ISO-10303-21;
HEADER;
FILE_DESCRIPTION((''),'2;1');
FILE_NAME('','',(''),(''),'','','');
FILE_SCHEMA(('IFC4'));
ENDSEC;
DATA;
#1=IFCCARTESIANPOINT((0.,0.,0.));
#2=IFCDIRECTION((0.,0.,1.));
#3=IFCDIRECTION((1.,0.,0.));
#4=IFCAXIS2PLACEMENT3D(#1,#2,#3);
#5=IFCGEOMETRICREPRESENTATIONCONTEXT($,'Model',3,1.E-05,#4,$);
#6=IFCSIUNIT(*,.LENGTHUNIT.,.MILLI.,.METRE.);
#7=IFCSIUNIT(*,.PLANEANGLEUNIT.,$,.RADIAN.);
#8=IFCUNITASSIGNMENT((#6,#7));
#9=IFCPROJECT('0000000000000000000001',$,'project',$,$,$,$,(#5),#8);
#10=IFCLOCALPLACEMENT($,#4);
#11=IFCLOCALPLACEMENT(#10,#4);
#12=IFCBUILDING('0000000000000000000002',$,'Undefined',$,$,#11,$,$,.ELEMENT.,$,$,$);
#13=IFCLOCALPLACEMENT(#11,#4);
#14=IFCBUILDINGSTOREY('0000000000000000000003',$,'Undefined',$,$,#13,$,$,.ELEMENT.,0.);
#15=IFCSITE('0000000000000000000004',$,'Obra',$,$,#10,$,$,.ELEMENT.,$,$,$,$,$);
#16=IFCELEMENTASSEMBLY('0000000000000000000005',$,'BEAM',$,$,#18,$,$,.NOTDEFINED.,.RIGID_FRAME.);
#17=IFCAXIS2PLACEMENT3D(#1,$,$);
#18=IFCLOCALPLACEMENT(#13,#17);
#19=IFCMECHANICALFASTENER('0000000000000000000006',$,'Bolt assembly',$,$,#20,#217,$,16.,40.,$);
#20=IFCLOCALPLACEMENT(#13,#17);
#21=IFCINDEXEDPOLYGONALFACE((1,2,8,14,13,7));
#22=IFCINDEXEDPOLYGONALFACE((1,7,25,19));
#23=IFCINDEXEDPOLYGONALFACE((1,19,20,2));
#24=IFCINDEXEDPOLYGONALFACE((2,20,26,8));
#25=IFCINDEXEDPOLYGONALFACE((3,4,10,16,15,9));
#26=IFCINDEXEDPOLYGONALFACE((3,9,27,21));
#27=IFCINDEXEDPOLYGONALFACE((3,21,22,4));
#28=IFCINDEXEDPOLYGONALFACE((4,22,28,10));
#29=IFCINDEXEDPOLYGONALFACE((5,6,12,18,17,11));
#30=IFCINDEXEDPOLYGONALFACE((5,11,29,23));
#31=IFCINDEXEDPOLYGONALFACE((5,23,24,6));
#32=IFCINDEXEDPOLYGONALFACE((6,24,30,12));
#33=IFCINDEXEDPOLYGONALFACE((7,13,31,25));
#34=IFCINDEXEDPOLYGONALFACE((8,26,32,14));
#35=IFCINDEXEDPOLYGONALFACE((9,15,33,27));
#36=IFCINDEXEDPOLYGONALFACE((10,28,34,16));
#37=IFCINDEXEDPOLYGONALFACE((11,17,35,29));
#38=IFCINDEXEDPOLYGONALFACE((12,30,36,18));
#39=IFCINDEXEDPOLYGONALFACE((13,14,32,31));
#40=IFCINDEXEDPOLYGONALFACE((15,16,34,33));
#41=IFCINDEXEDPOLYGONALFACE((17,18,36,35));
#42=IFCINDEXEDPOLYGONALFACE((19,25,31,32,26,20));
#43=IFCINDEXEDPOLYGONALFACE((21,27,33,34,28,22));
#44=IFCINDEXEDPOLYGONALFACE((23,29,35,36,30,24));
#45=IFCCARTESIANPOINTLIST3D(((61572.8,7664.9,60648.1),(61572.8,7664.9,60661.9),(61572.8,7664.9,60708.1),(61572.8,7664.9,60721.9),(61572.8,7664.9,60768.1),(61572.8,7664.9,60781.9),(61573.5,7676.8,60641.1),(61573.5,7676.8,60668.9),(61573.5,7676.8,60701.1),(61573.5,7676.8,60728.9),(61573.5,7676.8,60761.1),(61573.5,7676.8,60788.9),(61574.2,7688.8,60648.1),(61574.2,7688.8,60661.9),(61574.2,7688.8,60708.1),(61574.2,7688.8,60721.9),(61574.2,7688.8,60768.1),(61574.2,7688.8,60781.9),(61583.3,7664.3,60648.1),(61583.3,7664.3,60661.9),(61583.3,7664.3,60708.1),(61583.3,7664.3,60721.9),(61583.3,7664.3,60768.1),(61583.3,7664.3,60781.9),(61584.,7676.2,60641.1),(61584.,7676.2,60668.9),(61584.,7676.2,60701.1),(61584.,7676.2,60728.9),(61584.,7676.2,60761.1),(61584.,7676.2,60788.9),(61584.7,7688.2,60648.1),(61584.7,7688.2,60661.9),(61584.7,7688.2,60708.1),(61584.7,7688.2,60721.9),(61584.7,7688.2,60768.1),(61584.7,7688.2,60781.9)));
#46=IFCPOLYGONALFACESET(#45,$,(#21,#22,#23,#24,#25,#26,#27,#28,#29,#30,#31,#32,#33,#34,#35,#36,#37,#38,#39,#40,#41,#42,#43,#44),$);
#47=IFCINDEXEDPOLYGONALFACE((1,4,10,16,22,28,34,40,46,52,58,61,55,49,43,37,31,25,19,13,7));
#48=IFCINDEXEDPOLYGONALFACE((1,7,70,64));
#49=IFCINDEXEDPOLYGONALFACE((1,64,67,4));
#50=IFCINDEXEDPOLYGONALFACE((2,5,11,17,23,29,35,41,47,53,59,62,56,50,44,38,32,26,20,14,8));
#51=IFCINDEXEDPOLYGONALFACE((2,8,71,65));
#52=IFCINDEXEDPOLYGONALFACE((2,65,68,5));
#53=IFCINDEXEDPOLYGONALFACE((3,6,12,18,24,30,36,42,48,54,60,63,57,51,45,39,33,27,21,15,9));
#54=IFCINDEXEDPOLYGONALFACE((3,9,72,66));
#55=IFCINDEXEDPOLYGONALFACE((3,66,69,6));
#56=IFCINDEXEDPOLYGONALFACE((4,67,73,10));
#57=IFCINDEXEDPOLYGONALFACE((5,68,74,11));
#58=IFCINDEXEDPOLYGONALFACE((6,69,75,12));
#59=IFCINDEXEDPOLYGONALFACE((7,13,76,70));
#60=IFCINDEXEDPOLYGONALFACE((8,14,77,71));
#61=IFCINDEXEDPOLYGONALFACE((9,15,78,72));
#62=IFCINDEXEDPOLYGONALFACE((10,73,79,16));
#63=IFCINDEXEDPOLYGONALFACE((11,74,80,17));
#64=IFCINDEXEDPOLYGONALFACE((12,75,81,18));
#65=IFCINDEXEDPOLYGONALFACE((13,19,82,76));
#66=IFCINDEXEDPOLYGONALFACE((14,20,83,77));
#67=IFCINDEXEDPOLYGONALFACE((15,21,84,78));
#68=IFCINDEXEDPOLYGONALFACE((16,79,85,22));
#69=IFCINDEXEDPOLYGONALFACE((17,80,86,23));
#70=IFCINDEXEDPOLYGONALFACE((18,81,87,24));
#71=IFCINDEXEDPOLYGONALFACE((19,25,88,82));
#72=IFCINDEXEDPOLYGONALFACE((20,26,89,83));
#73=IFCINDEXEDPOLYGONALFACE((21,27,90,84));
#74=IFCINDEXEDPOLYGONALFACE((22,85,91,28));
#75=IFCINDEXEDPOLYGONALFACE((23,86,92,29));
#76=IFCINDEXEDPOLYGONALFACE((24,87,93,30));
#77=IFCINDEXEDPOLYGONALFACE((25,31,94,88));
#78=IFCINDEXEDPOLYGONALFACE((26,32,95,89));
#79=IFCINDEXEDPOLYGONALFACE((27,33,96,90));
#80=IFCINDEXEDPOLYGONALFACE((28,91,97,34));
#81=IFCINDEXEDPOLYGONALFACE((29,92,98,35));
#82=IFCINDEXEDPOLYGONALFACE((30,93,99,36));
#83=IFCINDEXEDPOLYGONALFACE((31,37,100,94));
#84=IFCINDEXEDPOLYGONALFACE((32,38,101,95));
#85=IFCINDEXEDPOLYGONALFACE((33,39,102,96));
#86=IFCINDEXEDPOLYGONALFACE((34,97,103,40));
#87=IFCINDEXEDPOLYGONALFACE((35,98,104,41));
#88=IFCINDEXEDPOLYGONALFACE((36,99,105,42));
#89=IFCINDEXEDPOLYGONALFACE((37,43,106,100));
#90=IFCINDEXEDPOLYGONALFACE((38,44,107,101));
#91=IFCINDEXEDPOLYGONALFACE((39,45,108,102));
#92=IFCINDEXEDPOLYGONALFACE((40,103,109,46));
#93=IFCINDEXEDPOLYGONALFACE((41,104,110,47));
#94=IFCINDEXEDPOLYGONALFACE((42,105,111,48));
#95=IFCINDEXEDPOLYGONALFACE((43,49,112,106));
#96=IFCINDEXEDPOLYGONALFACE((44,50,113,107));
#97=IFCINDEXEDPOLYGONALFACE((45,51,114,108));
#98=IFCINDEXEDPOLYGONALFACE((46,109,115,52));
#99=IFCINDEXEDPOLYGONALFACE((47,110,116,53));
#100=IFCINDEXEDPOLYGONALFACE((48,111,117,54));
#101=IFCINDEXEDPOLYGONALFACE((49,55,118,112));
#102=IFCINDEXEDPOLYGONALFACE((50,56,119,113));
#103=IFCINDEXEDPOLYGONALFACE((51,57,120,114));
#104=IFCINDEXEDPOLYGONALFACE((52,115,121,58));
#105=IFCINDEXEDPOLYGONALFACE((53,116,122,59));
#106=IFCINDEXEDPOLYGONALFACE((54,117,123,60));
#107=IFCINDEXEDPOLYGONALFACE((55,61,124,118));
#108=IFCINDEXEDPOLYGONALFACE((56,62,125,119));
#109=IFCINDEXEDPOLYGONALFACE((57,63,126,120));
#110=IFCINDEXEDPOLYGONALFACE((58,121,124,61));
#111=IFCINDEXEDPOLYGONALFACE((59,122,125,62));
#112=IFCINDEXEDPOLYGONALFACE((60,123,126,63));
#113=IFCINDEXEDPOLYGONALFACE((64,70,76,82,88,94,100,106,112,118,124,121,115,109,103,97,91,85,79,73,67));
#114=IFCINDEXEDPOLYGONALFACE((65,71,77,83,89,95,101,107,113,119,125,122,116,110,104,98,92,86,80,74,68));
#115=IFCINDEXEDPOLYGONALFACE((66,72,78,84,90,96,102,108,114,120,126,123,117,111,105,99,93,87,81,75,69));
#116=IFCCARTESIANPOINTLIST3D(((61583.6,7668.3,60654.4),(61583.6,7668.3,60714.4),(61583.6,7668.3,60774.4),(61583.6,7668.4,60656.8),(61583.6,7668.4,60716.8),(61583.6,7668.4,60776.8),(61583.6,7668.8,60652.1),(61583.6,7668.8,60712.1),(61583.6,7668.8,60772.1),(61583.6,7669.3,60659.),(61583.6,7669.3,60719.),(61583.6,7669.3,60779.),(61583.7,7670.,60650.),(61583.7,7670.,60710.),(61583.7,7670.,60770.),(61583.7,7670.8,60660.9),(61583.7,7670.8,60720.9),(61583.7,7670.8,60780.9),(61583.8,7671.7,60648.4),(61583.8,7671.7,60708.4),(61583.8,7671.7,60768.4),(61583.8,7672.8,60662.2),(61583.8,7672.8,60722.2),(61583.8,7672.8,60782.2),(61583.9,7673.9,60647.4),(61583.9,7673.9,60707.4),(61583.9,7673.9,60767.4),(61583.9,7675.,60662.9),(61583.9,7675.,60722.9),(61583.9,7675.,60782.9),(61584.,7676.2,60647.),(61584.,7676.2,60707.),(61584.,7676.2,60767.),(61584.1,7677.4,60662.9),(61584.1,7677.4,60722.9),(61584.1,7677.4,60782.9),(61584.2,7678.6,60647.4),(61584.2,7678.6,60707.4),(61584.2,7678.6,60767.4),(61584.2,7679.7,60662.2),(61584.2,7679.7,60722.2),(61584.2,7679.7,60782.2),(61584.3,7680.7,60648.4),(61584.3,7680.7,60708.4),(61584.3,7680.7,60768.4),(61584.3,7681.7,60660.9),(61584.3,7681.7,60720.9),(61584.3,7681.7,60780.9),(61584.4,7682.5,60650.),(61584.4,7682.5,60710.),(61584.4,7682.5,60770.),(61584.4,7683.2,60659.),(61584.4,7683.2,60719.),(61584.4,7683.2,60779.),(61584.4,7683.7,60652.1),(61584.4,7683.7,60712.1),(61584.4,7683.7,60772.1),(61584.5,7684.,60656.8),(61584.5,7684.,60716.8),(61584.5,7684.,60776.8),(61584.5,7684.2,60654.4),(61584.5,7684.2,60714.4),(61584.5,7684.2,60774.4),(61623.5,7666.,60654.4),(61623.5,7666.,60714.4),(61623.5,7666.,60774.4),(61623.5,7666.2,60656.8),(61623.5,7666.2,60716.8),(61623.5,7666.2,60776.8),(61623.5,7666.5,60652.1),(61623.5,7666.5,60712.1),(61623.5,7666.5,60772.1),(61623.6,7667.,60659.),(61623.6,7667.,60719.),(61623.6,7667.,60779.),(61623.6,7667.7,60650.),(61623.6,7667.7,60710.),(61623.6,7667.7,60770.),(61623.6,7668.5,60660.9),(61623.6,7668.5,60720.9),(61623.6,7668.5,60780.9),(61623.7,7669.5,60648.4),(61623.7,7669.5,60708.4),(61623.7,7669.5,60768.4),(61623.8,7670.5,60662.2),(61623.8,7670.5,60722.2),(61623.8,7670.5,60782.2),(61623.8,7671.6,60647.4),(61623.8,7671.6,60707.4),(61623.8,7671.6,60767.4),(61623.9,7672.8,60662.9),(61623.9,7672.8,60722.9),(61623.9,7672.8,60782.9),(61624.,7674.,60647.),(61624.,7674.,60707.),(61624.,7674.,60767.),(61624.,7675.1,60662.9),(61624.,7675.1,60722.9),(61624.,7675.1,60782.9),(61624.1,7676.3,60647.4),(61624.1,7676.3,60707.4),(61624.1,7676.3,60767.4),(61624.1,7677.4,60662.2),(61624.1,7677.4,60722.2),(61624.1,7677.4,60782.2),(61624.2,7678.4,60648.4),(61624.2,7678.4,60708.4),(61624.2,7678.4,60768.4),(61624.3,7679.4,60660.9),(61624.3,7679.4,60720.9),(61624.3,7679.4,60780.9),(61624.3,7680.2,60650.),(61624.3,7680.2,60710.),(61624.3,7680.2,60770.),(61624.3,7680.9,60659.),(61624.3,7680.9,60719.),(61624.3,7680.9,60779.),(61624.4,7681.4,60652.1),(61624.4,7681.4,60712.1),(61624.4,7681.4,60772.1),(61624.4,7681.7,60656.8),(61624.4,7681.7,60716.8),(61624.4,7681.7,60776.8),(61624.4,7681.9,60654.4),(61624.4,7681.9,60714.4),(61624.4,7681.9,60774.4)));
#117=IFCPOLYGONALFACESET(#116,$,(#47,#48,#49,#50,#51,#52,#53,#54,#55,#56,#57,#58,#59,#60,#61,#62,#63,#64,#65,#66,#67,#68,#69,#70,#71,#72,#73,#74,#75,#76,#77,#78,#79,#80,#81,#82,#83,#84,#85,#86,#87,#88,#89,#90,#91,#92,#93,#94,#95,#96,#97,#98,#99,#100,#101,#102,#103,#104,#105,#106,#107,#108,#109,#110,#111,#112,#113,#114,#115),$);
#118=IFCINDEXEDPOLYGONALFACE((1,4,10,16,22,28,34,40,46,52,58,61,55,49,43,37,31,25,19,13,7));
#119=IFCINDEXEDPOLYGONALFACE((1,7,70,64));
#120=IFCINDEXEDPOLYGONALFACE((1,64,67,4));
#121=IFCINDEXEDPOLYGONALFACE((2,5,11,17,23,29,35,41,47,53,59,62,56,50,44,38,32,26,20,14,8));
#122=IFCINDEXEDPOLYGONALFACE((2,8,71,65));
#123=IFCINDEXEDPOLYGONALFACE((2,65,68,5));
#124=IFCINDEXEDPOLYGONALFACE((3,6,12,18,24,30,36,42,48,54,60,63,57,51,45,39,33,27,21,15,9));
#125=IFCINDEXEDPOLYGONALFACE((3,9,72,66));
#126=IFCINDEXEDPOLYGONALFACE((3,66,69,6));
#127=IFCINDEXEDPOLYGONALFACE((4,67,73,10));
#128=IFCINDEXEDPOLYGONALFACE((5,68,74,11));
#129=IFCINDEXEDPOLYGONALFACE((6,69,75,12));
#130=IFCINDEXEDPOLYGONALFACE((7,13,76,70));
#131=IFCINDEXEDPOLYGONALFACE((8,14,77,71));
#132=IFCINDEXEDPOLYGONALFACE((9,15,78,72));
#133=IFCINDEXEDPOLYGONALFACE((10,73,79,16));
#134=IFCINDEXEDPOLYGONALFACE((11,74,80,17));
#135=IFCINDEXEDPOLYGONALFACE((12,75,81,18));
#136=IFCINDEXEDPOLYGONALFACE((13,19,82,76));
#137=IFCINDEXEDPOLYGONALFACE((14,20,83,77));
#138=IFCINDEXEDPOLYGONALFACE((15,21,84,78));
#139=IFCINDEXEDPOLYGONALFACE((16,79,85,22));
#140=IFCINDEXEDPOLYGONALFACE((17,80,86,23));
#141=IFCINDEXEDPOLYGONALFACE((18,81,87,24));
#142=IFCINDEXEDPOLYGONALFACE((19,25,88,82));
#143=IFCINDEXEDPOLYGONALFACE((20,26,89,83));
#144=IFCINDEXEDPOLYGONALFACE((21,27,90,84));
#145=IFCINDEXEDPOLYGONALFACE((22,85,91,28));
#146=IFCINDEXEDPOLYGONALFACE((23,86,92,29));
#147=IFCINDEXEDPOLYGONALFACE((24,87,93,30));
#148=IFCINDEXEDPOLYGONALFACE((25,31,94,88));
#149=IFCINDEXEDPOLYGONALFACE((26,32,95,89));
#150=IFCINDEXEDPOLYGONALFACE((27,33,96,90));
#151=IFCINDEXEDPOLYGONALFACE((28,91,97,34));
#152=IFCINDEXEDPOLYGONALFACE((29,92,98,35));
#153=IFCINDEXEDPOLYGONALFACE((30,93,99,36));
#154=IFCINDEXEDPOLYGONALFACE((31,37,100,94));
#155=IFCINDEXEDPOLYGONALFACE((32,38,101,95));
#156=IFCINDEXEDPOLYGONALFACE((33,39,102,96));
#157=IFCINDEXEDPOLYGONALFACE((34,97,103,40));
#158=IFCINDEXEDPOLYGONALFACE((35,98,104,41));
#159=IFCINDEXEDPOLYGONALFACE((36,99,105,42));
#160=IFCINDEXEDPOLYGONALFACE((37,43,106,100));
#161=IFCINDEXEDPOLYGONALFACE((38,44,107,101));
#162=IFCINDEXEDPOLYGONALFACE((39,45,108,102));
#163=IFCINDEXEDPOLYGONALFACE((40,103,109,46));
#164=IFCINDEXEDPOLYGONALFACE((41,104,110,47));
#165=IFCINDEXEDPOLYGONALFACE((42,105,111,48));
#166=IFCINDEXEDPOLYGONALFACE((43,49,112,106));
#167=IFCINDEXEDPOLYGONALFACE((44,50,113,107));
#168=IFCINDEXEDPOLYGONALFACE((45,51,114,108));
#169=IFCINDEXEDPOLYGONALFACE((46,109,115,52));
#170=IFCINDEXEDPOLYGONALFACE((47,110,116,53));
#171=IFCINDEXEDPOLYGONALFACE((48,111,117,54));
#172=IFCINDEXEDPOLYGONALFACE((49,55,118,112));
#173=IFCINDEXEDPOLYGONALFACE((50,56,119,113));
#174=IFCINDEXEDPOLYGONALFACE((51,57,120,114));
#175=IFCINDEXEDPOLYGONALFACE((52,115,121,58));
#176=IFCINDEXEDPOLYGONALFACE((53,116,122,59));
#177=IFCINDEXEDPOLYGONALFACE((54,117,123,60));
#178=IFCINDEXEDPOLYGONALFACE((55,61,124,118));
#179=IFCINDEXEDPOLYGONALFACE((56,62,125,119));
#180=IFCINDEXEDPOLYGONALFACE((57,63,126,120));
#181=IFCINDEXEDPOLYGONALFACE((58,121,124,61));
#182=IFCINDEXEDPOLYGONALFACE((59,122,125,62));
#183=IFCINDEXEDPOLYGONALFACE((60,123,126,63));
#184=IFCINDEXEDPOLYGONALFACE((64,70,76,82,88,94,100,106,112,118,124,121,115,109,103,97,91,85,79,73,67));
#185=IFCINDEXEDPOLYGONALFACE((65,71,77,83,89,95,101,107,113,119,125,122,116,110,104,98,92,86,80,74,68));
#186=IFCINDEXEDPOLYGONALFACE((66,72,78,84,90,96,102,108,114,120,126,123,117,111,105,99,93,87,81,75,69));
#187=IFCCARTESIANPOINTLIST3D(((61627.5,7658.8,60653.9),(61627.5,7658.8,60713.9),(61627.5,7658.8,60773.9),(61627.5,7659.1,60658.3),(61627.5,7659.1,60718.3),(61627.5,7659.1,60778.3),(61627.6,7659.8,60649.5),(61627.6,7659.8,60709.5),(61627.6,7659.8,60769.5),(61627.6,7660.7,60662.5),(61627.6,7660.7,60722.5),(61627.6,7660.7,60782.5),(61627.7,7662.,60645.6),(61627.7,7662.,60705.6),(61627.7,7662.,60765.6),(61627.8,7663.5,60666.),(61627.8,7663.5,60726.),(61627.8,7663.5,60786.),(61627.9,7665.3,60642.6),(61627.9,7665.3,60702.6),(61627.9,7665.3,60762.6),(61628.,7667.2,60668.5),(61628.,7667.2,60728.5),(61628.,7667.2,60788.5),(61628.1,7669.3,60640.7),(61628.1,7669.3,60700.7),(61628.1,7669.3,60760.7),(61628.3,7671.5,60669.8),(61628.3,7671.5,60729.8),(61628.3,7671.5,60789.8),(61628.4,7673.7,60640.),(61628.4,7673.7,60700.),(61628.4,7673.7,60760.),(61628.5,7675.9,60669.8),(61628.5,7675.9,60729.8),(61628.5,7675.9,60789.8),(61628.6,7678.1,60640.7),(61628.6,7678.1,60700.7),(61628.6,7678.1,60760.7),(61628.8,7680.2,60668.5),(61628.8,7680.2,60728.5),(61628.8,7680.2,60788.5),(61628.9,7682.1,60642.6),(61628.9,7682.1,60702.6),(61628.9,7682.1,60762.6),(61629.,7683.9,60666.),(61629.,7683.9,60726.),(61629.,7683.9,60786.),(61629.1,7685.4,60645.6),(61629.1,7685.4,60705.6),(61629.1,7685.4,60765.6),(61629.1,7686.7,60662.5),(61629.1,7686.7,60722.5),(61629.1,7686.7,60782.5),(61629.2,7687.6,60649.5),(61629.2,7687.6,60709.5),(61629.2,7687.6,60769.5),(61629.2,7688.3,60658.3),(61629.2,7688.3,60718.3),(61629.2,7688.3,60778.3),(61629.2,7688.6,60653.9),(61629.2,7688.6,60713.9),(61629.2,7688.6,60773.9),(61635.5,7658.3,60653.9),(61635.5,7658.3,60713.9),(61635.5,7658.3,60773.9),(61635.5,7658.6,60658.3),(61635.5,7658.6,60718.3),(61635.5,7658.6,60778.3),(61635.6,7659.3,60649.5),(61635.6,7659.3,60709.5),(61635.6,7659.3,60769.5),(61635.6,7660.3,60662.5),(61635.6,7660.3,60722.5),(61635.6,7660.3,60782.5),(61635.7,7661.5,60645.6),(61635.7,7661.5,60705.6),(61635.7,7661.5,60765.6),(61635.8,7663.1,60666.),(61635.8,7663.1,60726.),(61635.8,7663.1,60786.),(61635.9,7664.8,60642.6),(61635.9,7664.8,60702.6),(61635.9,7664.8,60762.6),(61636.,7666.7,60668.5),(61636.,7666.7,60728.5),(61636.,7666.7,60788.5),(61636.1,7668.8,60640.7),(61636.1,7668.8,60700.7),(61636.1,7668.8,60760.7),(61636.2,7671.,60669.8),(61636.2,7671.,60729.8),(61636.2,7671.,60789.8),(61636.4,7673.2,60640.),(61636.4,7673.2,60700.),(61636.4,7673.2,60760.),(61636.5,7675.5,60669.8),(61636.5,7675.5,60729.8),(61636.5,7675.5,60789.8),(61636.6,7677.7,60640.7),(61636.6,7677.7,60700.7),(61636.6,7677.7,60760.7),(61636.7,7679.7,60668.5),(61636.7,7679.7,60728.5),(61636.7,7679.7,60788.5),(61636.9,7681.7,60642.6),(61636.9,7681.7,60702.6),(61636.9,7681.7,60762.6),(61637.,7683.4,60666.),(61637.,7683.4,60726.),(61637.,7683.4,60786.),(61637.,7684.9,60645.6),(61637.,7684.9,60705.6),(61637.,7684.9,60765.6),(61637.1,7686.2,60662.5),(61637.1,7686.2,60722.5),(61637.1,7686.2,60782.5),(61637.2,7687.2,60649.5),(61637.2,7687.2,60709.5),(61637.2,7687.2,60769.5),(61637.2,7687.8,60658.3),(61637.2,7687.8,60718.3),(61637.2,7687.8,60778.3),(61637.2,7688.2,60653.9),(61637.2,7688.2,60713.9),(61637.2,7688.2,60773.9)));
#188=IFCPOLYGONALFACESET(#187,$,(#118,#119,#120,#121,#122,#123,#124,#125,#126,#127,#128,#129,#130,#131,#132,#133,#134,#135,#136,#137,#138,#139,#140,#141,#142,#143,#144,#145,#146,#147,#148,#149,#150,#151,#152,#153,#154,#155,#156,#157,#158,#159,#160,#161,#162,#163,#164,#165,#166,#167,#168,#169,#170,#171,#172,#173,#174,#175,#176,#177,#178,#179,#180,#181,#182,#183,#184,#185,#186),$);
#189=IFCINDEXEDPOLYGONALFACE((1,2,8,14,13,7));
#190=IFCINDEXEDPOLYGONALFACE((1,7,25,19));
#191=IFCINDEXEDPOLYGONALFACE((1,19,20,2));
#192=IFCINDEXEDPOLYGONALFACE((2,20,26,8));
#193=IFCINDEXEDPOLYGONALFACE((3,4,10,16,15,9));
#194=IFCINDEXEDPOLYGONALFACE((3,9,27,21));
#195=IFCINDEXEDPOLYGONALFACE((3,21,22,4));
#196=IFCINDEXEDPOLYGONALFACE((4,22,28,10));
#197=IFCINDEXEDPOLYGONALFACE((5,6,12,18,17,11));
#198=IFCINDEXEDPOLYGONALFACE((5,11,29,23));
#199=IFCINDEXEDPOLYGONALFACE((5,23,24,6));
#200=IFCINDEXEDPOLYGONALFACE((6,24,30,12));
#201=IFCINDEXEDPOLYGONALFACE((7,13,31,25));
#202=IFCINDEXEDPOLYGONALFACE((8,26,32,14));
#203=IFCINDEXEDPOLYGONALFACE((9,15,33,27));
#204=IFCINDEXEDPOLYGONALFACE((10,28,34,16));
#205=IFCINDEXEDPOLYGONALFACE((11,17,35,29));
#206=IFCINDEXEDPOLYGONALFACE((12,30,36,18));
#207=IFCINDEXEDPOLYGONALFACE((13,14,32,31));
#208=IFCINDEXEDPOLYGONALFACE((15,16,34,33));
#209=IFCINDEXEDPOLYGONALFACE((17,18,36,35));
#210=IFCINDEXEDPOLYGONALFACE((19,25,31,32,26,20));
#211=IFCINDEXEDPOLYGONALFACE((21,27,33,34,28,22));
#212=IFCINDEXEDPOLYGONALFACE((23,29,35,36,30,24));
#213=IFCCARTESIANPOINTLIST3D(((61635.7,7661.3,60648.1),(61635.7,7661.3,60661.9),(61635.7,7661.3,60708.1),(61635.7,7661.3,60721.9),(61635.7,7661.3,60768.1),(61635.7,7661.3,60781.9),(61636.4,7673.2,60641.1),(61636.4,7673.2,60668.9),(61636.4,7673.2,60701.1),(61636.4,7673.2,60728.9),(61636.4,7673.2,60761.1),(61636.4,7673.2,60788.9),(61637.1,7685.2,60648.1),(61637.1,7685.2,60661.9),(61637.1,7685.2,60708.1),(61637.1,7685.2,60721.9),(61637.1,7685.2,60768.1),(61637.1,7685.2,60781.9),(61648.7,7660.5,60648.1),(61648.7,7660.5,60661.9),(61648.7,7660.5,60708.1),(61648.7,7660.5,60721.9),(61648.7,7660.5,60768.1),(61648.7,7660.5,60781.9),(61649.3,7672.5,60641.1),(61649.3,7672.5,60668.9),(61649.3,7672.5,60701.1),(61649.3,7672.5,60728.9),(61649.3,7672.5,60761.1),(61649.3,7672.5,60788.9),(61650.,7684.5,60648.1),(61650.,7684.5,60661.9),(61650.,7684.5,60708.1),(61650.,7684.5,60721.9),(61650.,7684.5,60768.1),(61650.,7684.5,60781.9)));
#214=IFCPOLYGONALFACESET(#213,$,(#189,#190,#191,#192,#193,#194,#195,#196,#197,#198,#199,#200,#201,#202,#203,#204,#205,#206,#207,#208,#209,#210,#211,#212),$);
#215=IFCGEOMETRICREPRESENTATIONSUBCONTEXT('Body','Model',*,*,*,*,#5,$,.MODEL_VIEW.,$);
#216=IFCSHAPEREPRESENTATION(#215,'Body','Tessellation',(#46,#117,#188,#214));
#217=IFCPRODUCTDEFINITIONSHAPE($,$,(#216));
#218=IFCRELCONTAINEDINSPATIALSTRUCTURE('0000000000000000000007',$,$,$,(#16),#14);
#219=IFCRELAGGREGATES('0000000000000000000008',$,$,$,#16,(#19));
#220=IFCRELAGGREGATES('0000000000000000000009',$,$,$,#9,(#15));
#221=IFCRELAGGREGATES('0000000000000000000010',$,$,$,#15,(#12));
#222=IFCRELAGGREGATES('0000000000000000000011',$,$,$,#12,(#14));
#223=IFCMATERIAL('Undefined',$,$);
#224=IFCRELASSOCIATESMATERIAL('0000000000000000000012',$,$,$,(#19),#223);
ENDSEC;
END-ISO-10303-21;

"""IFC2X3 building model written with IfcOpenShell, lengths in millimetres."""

from ifc_helpers import new_model, si_unit, frame, origin_with_axes, origin_2d_with_axis, place, context, subcontext, project, spatial, polyline, circle, outline, extrude, source, transform, mapped, material, element, aggregate, save


model = new_model("IFC2X3")

# Units and contexts
model_context = context("Model", 3, precision=1e-05, world=origin_with_axes())
body_context = subcontext(model_context, "Body", "Model", "MODEL_VIEW")
ifc_project = project(units=[si_unit("LENGTHUNIT", "METRE", prefix="MILLI"), si_unit("PLANEANGLEUNIT", "RADIAN")], contexts=[model_context])

# Site, building, storey
site_placement = place(None, origin_with_axes())
site = spatial("IfcSite", under=ifc_project, at=site_placement, Name="Obra", CompositionType="ELEMENT")
building_placement = place(site_placement, origin_with_axes())
building = spatial("IfcBuilding", under=site, at=building_placement, Name="Undefined", CompositionType="ELEMENT")
storey_placement = place(building_placement, origin_with_axes())
storey = spatial("IfcBuildingStorey", under=building, at=storey_placement, Name="Undefined", CompositionType="ELEMENT", Elevation=0.0)

# Element assembly, mechanical fastener
ifc_material_1 = material(Name="Undefined")
shared_shape_1 = source(origin_with_axes(), body_context, "Body", "SweptSolid", [
    extrude(outline(polyline([(13.9, 0.0), (6.9, 12.0), (-6.9, 12.0), (-13.9, 0.0), (-6.9, -12.0), (6.9, -12.0), (13.9, 0.0)])), frame((0.0, -19.7, 0.0), z_axis=(0.0, 1.0, 0.0), x_axis=(1.0, 0.0, 0.0)), (0.0, 0.0, 1.0), 10.6),
    extrude(circle(Radius=8.0, at=origin_2d_with_axis()), frame((0.0, -9.1, 0.0), z_axis=(0.0, 1.0, 0.0), x_axis=(1.0, 0.0, 0.0)), (0.0, 0.0, 1.0), 40.0),
    extrude(circle(Radius=15.0, at=origin_2d_with_axis()), frame((0.0, 35.3, 0.0), z_axis=(0.0, 1.0, 0.0), x_axis=(1.0, 0.0, 0.0)), (0.0, 0.0, 1.0), 8.0),
    extrude(outline(polyline([(13.9, 0.0), (6.9, 12.0), (-6.9, 12.0), (-13.9, 0.0), (-6.9, -12.0), (6.9, -12.0), (13.9, 0.0)])), frame((0.0, 43.3, 0.0), z_axis=(0.0, 1.0, 0.0), x_axis=(1.0, 0.0, 0.0)), (0.0, 0.0, 1.0), 13.0),
])
assembly_1_placement = place(storey_placement, origin_with_axes())
assembly_1 = element("IfcElementAssembly", 1, at=assembly_1_placement, inside=storey, Name="BEAM", AssemblyPlace="NOTDEFINED", PredefinedType="RIGID_FRAME")
mechanical_fastener_1_placement = place(assembly_1_placement, frame((61596.0, 7725.6, 60835.0), z_axis=(-0.05711, -0.998368, 0.0), x_axis=(0.0, 0.0, -1.0)))
mechanical_fastener_1 = element("IfcMechanicalFastener", 2, at=mechanical_fastener_1_placement, material=ifc_material_1, Name="Bolt assembly", NominalDiameter=16.0, NominalLength=40.0, context=body_context, shape_type="MappedRepresentation", body=[
    mapped(shared_shape_1, transform((60.0, 0.0, 50.0))),
    mapped(shared_shape_1, transform((120.0, 0.0, 50.0))),
    mapped(shared_shape_1, transform((180.0, 0.0, 50.0))),
])

aggregate(assembly_1, [mechanical_fastener_1])

save(model, "model.ifc")
